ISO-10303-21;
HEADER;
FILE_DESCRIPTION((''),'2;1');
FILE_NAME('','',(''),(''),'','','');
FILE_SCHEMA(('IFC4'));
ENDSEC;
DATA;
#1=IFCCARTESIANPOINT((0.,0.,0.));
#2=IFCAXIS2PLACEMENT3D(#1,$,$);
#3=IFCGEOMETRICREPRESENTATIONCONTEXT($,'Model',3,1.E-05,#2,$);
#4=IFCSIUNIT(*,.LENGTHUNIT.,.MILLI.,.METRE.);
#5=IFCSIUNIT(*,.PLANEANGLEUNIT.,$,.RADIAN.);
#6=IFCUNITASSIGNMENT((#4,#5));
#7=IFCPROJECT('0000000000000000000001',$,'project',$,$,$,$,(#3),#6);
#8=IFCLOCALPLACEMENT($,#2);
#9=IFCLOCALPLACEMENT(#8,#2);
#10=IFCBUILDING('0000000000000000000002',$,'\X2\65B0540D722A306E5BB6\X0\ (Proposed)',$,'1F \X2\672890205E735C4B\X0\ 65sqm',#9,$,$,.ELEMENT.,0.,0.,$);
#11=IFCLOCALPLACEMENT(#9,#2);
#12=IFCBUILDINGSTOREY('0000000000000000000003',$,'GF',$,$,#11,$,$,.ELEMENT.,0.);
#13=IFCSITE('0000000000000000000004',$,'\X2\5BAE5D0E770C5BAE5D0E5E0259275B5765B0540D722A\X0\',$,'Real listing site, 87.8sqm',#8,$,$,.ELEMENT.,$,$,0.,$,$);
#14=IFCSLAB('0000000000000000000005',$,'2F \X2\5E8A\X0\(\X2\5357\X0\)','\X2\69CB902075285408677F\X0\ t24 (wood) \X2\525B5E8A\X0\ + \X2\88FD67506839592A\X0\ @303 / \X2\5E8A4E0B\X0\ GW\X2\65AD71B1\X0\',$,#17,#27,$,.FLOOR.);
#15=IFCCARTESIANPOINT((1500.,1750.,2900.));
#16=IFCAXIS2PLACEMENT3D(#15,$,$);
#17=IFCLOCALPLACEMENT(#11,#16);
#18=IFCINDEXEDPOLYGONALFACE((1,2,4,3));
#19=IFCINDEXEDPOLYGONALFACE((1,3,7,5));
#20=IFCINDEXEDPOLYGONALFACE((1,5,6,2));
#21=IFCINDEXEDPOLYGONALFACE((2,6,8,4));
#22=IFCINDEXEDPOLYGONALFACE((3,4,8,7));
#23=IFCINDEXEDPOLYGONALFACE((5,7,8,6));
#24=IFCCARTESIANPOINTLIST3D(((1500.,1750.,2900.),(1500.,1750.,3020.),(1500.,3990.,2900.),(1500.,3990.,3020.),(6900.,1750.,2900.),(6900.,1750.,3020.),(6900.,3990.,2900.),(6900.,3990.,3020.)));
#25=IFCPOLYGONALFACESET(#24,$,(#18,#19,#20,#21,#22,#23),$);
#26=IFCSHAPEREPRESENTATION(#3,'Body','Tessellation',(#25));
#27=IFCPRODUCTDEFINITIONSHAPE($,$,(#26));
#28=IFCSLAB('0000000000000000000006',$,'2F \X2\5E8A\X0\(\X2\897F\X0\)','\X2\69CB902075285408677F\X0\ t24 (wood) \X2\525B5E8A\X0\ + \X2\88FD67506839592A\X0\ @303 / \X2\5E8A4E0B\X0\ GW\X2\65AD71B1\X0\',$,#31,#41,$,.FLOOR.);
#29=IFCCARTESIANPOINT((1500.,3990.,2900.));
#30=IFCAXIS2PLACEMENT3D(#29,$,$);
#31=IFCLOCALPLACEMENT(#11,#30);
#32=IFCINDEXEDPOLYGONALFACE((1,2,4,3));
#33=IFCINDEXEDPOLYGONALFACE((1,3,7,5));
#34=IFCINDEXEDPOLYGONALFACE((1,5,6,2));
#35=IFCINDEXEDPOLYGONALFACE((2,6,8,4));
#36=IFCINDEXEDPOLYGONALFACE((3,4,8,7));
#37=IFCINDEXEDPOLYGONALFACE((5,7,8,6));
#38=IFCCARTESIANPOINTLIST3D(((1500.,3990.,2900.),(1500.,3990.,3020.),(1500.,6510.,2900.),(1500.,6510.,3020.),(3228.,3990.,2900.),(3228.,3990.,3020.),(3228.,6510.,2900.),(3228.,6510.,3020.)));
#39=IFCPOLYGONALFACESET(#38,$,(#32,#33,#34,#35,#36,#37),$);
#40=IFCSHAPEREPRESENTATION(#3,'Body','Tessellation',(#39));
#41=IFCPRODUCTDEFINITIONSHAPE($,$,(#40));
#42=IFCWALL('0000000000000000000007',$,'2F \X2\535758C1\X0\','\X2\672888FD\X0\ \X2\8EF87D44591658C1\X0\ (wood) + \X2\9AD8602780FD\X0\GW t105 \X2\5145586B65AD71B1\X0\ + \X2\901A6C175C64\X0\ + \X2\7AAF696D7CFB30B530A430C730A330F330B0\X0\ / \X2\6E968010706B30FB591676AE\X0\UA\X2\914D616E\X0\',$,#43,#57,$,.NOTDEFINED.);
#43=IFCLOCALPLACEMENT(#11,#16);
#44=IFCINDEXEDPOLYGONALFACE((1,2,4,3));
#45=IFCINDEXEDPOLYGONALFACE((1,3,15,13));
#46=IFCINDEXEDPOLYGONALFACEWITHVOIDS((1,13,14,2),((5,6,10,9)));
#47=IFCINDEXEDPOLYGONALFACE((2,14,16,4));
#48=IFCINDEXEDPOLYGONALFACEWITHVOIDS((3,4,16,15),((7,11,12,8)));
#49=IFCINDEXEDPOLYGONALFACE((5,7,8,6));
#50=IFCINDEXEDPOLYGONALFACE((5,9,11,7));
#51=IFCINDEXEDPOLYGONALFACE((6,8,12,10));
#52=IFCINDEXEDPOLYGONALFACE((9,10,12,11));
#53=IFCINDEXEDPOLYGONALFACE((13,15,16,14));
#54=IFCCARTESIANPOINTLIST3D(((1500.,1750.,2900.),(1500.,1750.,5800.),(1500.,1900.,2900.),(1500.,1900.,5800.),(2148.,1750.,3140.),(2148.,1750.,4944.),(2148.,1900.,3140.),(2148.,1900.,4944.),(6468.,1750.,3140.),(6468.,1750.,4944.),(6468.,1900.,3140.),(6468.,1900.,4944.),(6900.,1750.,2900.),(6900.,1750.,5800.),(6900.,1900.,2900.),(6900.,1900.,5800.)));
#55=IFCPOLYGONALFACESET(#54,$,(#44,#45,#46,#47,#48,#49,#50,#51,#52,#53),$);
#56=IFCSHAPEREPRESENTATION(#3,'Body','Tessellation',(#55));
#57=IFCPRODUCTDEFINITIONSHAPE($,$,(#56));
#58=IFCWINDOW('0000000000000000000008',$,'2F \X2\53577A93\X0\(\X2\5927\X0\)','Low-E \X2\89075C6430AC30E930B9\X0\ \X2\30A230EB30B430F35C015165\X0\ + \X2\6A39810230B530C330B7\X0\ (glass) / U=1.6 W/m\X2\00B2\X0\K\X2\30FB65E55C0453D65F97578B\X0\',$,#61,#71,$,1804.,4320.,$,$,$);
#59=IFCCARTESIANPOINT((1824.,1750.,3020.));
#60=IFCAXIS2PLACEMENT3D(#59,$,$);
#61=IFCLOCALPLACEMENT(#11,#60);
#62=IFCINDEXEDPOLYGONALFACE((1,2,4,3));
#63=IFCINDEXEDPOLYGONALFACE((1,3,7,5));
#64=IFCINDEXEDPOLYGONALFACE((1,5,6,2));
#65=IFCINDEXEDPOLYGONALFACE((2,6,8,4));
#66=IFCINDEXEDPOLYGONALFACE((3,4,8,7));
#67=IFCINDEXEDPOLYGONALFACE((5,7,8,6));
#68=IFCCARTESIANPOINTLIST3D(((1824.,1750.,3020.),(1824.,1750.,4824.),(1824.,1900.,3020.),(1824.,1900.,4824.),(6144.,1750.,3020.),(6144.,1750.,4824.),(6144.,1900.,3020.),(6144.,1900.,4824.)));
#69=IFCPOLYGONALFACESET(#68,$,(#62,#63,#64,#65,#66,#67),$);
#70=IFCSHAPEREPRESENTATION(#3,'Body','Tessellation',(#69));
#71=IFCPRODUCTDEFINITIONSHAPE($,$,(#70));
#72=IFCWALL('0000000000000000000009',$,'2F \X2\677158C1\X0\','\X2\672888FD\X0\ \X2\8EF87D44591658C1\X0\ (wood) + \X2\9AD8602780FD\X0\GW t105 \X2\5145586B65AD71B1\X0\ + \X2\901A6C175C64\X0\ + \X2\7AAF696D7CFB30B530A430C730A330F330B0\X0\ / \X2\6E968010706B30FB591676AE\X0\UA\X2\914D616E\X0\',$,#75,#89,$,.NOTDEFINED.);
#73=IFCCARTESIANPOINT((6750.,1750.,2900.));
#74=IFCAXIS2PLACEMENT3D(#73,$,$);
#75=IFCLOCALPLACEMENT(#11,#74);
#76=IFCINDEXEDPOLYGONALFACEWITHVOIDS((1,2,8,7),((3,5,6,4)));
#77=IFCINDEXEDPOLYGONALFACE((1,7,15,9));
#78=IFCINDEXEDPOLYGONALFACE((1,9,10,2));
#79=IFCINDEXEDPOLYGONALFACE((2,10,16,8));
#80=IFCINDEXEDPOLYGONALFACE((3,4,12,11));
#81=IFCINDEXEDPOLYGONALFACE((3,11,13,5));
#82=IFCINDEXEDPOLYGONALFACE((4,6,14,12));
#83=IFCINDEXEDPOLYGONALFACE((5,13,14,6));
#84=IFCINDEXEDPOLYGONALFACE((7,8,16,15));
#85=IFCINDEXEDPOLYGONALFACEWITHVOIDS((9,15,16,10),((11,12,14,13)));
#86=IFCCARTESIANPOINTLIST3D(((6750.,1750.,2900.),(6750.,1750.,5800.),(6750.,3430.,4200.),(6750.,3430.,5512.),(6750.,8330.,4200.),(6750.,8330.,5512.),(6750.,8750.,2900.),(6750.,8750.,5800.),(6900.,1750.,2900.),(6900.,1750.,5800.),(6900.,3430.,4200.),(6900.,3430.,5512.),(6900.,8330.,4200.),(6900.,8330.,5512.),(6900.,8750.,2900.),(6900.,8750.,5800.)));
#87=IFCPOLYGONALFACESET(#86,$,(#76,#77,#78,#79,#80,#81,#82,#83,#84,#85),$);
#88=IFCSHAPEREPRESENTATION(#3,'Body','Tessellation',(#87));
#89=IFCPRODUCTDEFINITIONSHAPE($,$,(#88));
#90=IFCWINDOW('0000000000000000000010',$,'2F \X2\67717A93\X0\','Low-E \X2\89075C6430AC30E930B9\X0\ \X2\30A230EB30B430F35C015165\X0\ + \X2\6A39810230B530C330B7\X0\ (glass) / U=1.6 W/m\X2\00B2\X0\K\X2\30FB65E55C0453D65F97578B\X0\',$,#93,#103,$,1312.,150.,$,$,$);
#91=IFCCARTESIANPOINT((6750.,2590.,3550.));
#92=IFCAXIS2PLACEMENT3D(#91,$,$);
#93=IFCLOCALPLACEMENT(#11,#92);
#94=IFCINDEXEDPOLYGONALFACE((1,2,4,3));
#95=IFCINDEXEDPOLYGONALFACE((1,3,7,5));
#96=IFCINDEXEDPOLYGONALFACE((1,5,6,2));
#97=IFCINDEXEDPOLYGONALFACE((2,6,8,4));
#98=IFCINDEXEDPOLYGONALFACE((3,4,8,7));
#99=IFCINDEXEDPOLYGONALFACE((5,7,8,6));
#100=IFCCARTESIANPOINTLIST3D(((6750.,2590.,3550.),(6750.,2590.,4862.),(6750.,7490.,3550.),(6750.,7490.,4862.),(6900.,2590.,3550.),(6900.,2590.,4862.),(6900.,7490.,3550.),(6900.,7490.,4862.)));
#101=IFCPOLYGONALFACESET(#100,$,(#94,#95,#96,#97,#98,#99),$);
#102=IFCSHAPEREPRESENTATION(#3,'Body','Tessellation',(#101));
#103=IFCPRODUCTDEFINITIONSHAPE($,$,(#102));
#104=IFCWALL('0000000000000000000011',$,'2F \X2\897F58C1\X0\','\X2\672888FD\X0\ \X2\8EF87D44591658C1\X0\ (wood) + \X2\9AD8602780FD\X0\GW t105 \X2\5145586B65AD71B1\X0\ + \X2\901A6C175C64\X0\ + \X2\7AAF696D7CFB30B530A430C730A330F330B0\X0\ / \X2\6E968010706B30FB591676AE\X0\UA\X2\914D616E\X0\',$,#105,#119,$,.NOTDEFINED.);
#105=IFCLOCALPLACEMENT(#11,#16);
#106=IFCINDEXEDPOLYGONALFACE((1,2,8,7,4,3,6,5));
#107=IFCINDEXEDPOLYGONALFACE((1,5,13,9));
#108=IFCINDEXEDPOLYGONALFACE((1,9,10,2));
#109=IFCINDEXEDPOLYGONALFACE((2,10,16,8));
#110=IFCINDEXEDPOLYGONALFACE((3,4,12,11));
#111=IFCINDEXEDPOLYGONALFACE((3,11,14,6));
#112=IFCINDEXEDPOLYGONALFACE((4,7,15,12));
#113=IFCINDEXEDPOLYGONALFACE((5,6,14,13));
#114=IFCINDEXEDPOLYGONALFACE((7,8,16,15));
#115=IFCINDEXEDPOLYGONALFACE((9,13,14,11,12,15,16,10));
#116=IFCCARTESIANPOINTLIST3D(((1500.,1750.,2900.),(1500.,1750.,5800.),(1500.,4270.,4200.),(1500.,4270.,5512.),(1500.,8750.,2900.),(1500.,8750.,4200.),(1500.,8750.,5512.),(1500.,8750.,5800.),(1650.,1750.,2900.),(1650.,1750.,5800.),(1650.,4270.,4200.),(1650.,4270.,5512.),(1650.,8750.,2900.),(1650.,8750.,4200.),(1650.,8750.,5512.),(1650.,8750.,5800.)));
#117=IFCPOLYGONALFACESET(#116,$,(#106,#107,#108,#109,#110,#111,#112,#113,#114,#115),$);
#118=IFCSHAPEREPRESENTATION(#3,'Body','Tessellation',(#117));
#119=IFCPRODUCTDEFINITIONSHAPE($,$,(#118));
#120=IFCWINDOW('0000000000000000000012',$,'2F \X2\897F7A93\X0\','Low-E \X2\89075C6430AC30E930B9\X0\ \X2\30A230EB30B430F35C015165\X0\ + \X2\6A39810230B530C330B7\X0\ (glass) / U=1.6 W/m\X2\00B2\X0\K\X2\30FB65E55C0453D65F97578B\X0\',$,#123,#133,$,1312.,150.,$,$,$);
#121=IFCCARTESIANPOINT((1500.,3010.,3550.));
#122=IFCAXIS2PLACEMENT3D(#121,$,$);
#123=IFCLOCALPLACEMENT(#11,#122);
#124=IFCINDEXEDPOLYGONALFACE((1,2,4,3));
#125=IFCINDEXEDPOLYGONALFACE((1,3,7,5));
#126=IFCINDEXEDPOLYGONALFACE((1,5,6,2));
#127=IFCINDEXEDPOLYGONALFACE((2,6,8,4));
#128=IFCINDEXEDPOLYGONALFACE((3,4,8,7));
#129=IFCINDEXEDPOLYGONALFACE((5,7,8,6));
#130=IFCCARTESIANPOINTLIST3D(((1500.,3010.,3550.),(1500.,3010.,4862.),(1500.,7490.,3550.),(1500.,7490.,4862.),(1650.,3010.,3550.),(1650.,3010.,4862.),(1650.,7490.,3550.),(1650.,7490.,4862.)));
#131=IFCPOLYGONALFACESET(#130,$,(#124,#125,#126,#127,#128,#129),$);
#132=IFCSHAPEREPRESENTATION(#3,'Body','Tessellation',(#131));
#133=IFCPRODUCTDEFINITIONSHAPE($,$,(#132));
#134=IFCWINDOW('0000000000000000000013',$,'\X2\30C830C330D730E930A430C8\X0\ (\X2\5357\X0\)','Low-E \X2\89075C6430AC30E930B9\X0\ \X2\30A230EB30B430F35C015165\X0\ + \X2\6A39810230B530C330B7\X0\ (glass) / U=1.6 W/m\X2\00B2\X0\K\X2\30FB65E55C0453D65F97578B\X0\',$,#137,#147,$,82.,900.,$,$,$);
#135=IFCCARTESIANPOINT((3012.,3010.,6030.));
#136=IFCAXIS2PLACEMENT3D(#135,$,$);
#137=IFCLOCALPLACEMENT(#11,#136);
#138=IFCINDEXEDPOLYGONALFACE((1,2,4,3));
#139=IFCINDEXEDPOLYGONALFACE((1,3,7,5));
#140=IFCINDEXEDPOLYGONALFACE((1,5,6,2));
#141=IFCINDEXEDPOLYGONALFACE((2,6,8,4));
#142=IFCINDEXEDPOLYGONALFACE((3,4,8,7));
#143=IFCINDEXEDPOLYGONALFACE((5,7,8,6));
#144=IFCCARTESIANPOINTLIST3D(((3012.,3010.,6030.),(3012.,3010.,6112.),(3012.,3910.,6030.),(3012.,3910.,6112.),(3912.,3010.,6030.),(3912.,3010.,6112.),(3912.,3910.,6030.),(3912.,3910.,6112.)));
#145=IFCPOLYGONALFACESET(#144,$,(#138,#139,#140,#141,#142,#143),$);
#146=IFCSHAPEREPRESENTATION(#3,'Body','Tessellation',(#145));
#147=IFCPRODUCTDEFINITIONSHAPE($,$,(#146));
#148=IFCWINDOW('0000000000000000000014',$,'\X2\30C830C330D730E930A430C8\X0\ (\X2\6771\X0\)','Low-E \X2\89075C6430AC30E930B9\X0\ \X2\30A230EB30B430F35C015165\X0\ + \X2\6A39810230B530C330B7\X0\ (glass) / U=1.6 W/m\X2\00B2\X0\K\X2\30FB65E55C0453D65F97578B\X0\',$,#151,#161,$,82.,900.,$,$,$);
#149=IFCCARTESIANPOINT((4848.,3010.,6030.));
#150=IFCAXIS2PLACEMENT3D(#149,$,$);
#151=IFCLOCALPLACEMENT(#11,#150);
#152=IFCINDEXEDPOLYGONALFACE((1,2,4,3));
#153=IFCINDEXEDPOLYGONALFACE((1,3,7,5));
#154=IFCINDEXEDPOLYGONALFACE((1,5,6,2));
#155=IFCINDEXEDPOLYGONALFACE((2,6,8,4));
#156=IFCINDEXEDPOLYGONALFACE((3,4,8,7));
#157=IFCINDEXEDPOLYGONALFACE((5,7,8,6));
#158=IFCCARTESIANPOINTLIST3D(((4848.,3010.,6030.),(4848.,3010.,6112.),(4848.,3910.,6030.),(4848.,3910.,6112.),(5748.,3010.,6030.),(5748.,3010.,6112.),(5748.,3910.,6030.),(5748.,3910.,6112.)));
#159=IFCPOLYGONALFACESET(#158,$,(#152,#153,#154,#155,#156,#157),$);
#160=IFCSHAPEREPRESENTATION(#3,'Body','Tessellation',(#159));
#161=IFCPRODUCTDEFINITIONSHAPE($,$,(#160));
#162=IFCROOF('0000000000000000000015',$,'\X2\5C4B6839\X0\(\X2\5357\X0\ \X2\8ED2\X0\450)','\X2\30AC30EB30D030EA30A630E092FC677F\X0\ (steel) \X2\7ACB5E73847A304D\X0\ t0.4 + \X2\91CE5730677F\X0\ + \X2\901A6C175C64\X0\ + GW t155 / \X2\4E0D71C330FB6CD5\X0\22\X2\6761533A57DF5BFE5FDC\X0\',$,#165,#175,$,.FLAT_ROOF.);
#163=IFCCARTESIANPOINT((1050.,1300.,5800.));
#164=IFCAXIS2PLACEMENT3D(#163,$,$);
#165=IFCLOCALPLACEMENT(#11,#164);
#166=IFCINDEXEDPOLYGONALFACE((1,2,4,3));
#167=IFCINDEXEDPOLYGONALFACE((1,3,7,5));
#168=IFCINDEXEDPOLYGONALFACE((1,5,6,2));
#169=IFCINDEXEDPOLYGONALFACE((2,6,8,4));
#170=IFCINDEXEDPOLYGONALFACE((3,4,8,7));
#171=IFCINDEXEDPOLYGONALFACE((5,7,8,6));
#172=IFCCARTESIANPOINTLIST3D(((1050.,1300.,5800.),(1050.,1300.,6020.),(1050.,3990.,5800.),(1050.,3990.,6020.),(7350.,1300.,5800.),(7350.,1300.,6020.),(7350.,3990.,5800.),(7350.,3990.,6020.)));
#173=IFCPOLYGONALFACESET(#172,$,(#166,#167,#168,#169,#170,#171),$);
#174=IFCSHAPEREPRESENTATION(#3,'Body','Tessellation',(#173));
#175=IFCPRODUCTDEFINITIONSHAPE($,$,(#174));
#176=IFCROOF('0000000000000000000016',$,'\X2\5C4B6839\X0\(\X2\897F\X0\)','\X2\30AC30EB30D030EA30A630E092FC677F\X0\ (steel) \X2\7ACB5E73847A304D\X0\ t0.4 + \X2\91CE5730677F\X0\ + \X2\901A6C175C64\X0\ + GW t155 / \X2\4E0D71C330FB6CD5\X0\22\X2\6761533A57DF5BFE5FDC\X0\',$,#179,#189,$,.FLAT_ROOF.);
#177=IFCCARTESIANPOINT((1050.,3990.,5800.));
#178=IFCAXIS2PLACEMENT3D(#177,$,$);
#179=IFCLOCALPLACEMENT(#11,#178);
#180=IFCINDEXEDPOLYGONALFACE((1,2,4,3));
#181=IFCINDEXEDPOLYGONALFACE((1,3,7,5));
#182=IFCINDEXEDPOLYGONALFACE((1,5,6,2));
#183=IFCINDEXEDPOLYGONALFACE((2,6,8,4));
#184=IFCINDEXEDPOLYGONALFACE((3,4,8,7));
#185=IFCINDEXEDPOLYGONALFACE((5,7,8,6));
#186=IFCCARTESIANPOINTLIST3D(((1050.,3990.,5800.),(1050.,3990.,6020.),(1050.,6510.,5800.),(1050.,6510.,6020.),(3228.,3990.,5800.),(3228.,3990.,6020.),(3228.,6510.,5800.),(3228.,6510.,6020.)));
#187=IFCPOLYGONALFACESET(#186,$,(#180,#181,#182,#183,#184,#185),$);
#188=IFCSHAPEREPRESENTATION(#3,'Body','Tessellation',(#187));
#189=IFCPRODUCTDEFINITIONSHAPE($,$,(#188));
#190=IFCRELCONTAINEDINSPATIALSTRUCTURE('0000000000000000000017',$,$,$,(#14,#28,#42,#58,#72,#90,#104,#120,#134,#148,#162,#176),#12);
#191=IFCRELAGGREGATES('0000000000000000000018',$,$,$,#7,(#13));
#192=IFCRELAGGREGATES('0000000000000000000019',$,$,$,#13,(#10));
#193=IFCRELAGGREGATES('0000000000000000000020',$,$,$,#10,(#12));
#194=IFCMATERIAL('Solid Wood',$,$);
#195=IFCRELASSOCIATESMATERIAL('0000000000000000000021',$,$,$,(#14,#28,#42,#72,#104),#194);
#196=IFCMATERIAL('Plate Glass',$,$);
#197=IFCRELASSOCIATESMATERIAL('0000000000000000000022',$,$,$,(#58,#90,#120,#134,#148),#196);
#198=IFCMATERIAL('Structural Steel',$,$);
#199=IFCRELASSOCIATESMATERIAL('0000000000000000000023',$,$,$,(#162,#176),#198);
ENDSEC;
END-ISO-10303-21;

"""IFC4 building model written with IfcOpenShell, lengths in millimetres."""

from ifc_helpers import new_model, si_unit, frame, frame_2d, origin, place, context, project, spatial, rectangle, extrude, material, element, fill, save


model = new_model("IFC4")

# Units and contexts
model_context = context("Model", 3, precision=1e-05, world=origin())
ifc_project = project(units=[si_unit("LENGTHUNIT", "METRE", prefix="MILLI"), si_unit("PLANEANGLEUNIT", "RADIAN")], contexts=[model_context])

# Site, building, storey
site_placement = place(None, origin())
site = spatial("IfcSite", under=ifc_project, at=site_placement, Name="宮崎県宮崎市大字新名爪", ObjectType="Real listing site, 87.8sqm", CompositionType="ELEMENT", RefElevation=0.0)
building_placement = place(site_placement, origin())
building = spatial("IfcBuilding", under=site, at=building_placement, Name="新名爪の家 (Proposed)", ObjectType="1F 木造平屋 65sqm", CompositionType="ELEMENT", ElevationOfRefHeight=0.0, ElevationOfTerrain=0.0)
storey_placement = place(building_placement, origin())
storey = spatial("IfcBuildingStorey", under=building, at=storey_placement, Name="GF", CompositionType="ELEMENT", Elevation=0.0)

# Slabs
ifc_material_1 = material(Name="Solid Wood")
slab_1_placement = place(storey_placement, frame((1500.0, 1750.0, 2900.0)))
element("IfcSlab", 1, at=slab_1_placement, inside=storey, material=ifc_material_1, Name="2F 床(南)", Description="構造用合板 t24 (wood) 剛床 + 製材根太 @303 / 床下 GW断熱", PredefinedType="FLOOR", context=model_context, shape_type="SweptSolid", body=[
    extrude(rectangle(XDim=5400.0, YDim=2240.0, at=frame_2d((2700.0, 1120.0))), frame((1500.0, 1750.0, 2900.0)), (0.0, 0.0, 1.0), 120.0),
])
slab_2_placement = place(storey_placement, frame((1500.0, 3990.0, 2900.0)))
element("IfcSlab", 2, at=slab_2_placement, inside=storey, material=ifc_material_1, Name="2F 床(西)", Description="構造用合板 t24 (wood) 剛床 + 製材根太 @303 / 床下 GW断熱", PredefinedType="FLOOR", context=model_context, shape_type="SweptSolid", body=[
    extrude(rectangle(XDim=1728.0, YDim=2520.0, at=frame_2d((864.0, 1260.0))), frame((1500.0, 3990.0, 2900.0)), (0.0, 0.0, 1.0), 120.0),
])

# Walls, openings, windows
wall_1_placement = place(storey_placement, frame((1500.0, 1750.0, 2900.0)))
wall_1 = element("IfcWall", 3, at=wall_1_placement, inside=storey, material=ifc_material_1, Name="2F 南壁", Description="木製 軸組外壁 (wood) + 高性能GW t105 充填断熱 + 通気層 + 窯業系サイディング / 準耐火・外皮UA配慮", PredefinedType="NOTDEFINED", context=model_context, shape_type="SweptSolid", body=[
    extrude(rectangle(XDim=5400.0, YDim=150.0, at=frame_2d((2700.0, 75.0))), frame((1500.0, 1750.0, 2900.0)), (0.0, 0.0, 1.0), 2900.0),
])
opening_1_placement = place(storey_placement, frame((1824.0, 1750.0, 3020.0)))
opening_1 = element("IfcOpeningElement", 4, at=opening_1_placement, cuts=wall_1, PredefinedType="NOTDEFINED", context=model_context, shape_type="SweptSolid", body=[
    extrude(rectangle(XDim=4320.0, YDim=150.0, at=frame_2d((2160.0, 75.0))), frame((1824.0, 1750.0, 3020.0)), (0.0, 0.0, 1.0), 1804.0),
])
ifc_material_2 = material(Name="Plate Glass")
window_1_placement = place(storey_placement, frame((1824.0, 1750.0, 3020.0)))
window_1 = element("IfcWindow", 5, at=window_1_placement, inside=storey, material=ifc_material_2, Name="2F 南窓(大)", Description="Low-E 複層ガラス アルゴン封入 + 樹脂サッシ (glass) / U=1.6 W/m²K・日射取得型", OverallHeight=1804.0, OverallWidth=4320.0, context=model_context, shape_type="SweptSolid", body=[
    extrude(rectangle(XDim=4320.0, YDim=150.0, at=frame_2d((2160.0, 75.0))), frame((1824.0, 1750.0, 3020.0)), (0.0, 0.0, 1.0), 1804.0),
])
fill(opening_1, window_1)
wall_2_placement = place(storey_placement, frame((6750.0, 1750.0, 2900.0)))
wall_2 = element("IfcWall", 6, at=wall_2_placement, inside=storey, material=ifc_material_1, Name="2F 東壁", Description="木製 軸組外壁 (wood) + 高性能GW t105 充填断熱 + 通気層 + 窯業系サイディング / 準耐火・外皮UA配慮", PredefinedType="NOTDEFINED", context=model_context, shape_type="SweptSolid", body=[
    extrude(rectangle(XDim=150.0, YDim=7000.0, at=frame_2d((75.0, 3500.0))), frame((6750.0, 1750.0, 2900.0)), (0.0, 0.0, 1.0), 2900.0),
])
opening_2_placement = place(storey_placement, frame((6750.0, 2590.0, 3550.0)))
opening_2 = element("IfcOpeningElement", 7, at=opening_2_placement, cuts=wall_2, PredefinedType="NOTDEFINED", context=model_context, shape_type="SweptSolid", body=[
    extrude(rectangle(XDim=150.0, YDim=4900.0, at=frame_2d((75.0, 2450.0))), frame((6750.0, 2590.0, 3550.0)), (0.0, 0.0, 1.0), 1312.0),
])
window_2_placement = place(storey_placement, frame((6750.0, 2590.0, 3550.0)))
window_2 = element("IfcWindow", 8, at=window_2_placement, inside=storey, material=ifc_material_2, Name="2F 東窓", Description="Low-E 複層ガラス アルゴン封入 + 樹脂サッシ (glass) / U=1.6 W/m²K・日射取得型", OverallHeight=1312.0, OverallWidth=150.0, context=model_context, shape_type="SweptSolid", body=[
    extrude(rectangle(XDim=150.0, YDim=4900.0, at=frame_2d((75.0, 2450.0))), frame((6750.0, 2590.0, 3550.0)), (0.0, 0.0, 1.0), 1312.0),
])
fill(opening_2, window_2)
wall_3_placement = place(storey_placement, frame((1500.0, 1750.0, 2900.0)))
wall_3 = element("IfcWall", 9, at=wall_3_placement, inside=storey, material=ifc_material_1, Name="2F 西壁", Description="木製 軸組外壁 (wood) + 高性能GW t105 充填断熱 + 通気層 + 窯業系サイディング / 準耐火・外皮UA配慮", PredefinedType="NOTDEFINED", context=model_context, shape_type="SweptSolid", body=[
    extrude(rectangle(XDim=150.0, YDim=7000.0, at=frame_2d((75.0, 3500.0))), frame((1500.0, 1750.0, 2900.0)), (0.0, 0.0, 1.0), 2900.0),
])
opening_3_placement = place(storey_placement, frame((1500.0, 3010.0, 3550.0)))
opening_3 = element("IfcOpeningElement", 10, at=opening_3_placement, cuts=wall_3, PredefinedType="NOTDEFINED", context=model_context, shape_type="SweptSolid", body=[
    extrude(rectangle(XDim=150.0, YDim=4480.0, at=frame_2d((75.0, 2240.0))), frame((1500.0, 3010.0, 3550.0)), (0.0, 0.0, 1.0), 1312.0),
])
window_3_placement = place(storey_placement, frame((1500.0, 3010.0, 3550.0)))
window_3 = element("IfcWindow", 11, at=window_3_placement, inside=storey, material=ifc_material_2, Name="2F 西窓", Description="Low-E 複層ガラス アルゴン封入 + 樹脂サッシ (glass) / U=1.6 W/m²K・日射取得型", OverallHeight=1312.0, OverallWidth=150.0, context=model_context, shape_type="SweptSolid", body=[
    extrude(rectangle(XDim=150.0, YDim=4480.0, at=frame_2d((75.0, 2240.0))), frame((1500.0, 3010.0, 3550.0)), (0.0, 0.0, 1.0), 1312.0),
])
fill(opening_3, window_3)

# Windows
window_4_placement = place(storey_placement, frame((3012.0, 3010.0, 6030.0)))
element("IfcWindow", 12, at=window_4_placement, inside=storey, material=ifc_material_2, Name="トップライト (南)", Description="Low-E 複層ガラス アルゴン封入 + 樹脂サッシ (glass) / U=1.6 W/m²K・日射取得型", OverallHeight=82.0, OverallWidth=900.0, context=model_context, shape_type="SweptSolid", body=[
    extrude(rectangle(XDim=900.0, YDim=900.0, at=frame_2d((450.0, 450.0))), frame((3012.0, 3010.0, 6030.0)), (0.0, 0.0, 1.0), 82.0),
])
window_5_placement = place(storey_placement, frame((4848.0, 3010.0, 6030.0)))
element("IfcWindow", 13, at=window_5_placement, inside=storey, material=ifc_material_2, Name="トップライト (東)", Description="Low-E 複層ガラス アルゴン封入 + 樹脂サッシ (glass) / U=1.6 W/m²K・日射取得型", OverallHeight=82.0, OverallWidth=900.0, context=model_context, shape_type="SweptSolid", body=[
    extrude(rectangle(XDim=900.0, YDim=900.0, at=frame_2d((450.0, 450.0))), frame((4848.0, 3010.0, 6030.0)), (0.0, 0.0, 1.0), 82.0),
])

# Roofs
ifc_material_3 = material(Name="Structural Steel")
roof_1_placement = place(storey_placement, frame((1050.0, 1300.0, 5800.0)))
element("IfcRoof", 14, at=roof_1_placement, inside=storey, material=ifc_material_3, Name="屋根(南 軒450)", Description="ガルバリウム鋼板 (steel) 立平葺き t0.4 + 野地板 + 通気層 + GW t155 / 不燃・法22条区域対応", PredefinedType="FLAT_ROOF", context=model_context, shape_type="SweptSolid", body=[
    extrude(rectangle(XDim=6300.0, YDim=2690.0, at=frame_2d((3150.0, 1345.0))), frame((1050.0, 1300.0, 5800.0)), (0.0, 0.0, 1.0), 220.0),
])
roof_2_placement = place(storey_placement, frame((1050.0, 3990.0, 5800.0)))
element("IfcRoof", 15, at=roof_2_placement, inside=storey, material=ifc_material_3, Name="屋根(西)", Description="ガルバリウム鋼板 (steel) 立平葺き t0.4 + 野地板 + 通気層 + GW t155 / 不燃・法22条区域対応", PredefinedType="FLAT_ROOF", context=model_context, shape_type="SweptSolid", body=[
    extrude(rectangle(XDim=2178.0, YDim=2520.0, at=frame_2d((1089.0, 1260.0))), frame((1050.0, 3990.0, 5800.0)), (0.0, 0.0, 1.0), 220.0),
])

save(model, "model.ifc")
